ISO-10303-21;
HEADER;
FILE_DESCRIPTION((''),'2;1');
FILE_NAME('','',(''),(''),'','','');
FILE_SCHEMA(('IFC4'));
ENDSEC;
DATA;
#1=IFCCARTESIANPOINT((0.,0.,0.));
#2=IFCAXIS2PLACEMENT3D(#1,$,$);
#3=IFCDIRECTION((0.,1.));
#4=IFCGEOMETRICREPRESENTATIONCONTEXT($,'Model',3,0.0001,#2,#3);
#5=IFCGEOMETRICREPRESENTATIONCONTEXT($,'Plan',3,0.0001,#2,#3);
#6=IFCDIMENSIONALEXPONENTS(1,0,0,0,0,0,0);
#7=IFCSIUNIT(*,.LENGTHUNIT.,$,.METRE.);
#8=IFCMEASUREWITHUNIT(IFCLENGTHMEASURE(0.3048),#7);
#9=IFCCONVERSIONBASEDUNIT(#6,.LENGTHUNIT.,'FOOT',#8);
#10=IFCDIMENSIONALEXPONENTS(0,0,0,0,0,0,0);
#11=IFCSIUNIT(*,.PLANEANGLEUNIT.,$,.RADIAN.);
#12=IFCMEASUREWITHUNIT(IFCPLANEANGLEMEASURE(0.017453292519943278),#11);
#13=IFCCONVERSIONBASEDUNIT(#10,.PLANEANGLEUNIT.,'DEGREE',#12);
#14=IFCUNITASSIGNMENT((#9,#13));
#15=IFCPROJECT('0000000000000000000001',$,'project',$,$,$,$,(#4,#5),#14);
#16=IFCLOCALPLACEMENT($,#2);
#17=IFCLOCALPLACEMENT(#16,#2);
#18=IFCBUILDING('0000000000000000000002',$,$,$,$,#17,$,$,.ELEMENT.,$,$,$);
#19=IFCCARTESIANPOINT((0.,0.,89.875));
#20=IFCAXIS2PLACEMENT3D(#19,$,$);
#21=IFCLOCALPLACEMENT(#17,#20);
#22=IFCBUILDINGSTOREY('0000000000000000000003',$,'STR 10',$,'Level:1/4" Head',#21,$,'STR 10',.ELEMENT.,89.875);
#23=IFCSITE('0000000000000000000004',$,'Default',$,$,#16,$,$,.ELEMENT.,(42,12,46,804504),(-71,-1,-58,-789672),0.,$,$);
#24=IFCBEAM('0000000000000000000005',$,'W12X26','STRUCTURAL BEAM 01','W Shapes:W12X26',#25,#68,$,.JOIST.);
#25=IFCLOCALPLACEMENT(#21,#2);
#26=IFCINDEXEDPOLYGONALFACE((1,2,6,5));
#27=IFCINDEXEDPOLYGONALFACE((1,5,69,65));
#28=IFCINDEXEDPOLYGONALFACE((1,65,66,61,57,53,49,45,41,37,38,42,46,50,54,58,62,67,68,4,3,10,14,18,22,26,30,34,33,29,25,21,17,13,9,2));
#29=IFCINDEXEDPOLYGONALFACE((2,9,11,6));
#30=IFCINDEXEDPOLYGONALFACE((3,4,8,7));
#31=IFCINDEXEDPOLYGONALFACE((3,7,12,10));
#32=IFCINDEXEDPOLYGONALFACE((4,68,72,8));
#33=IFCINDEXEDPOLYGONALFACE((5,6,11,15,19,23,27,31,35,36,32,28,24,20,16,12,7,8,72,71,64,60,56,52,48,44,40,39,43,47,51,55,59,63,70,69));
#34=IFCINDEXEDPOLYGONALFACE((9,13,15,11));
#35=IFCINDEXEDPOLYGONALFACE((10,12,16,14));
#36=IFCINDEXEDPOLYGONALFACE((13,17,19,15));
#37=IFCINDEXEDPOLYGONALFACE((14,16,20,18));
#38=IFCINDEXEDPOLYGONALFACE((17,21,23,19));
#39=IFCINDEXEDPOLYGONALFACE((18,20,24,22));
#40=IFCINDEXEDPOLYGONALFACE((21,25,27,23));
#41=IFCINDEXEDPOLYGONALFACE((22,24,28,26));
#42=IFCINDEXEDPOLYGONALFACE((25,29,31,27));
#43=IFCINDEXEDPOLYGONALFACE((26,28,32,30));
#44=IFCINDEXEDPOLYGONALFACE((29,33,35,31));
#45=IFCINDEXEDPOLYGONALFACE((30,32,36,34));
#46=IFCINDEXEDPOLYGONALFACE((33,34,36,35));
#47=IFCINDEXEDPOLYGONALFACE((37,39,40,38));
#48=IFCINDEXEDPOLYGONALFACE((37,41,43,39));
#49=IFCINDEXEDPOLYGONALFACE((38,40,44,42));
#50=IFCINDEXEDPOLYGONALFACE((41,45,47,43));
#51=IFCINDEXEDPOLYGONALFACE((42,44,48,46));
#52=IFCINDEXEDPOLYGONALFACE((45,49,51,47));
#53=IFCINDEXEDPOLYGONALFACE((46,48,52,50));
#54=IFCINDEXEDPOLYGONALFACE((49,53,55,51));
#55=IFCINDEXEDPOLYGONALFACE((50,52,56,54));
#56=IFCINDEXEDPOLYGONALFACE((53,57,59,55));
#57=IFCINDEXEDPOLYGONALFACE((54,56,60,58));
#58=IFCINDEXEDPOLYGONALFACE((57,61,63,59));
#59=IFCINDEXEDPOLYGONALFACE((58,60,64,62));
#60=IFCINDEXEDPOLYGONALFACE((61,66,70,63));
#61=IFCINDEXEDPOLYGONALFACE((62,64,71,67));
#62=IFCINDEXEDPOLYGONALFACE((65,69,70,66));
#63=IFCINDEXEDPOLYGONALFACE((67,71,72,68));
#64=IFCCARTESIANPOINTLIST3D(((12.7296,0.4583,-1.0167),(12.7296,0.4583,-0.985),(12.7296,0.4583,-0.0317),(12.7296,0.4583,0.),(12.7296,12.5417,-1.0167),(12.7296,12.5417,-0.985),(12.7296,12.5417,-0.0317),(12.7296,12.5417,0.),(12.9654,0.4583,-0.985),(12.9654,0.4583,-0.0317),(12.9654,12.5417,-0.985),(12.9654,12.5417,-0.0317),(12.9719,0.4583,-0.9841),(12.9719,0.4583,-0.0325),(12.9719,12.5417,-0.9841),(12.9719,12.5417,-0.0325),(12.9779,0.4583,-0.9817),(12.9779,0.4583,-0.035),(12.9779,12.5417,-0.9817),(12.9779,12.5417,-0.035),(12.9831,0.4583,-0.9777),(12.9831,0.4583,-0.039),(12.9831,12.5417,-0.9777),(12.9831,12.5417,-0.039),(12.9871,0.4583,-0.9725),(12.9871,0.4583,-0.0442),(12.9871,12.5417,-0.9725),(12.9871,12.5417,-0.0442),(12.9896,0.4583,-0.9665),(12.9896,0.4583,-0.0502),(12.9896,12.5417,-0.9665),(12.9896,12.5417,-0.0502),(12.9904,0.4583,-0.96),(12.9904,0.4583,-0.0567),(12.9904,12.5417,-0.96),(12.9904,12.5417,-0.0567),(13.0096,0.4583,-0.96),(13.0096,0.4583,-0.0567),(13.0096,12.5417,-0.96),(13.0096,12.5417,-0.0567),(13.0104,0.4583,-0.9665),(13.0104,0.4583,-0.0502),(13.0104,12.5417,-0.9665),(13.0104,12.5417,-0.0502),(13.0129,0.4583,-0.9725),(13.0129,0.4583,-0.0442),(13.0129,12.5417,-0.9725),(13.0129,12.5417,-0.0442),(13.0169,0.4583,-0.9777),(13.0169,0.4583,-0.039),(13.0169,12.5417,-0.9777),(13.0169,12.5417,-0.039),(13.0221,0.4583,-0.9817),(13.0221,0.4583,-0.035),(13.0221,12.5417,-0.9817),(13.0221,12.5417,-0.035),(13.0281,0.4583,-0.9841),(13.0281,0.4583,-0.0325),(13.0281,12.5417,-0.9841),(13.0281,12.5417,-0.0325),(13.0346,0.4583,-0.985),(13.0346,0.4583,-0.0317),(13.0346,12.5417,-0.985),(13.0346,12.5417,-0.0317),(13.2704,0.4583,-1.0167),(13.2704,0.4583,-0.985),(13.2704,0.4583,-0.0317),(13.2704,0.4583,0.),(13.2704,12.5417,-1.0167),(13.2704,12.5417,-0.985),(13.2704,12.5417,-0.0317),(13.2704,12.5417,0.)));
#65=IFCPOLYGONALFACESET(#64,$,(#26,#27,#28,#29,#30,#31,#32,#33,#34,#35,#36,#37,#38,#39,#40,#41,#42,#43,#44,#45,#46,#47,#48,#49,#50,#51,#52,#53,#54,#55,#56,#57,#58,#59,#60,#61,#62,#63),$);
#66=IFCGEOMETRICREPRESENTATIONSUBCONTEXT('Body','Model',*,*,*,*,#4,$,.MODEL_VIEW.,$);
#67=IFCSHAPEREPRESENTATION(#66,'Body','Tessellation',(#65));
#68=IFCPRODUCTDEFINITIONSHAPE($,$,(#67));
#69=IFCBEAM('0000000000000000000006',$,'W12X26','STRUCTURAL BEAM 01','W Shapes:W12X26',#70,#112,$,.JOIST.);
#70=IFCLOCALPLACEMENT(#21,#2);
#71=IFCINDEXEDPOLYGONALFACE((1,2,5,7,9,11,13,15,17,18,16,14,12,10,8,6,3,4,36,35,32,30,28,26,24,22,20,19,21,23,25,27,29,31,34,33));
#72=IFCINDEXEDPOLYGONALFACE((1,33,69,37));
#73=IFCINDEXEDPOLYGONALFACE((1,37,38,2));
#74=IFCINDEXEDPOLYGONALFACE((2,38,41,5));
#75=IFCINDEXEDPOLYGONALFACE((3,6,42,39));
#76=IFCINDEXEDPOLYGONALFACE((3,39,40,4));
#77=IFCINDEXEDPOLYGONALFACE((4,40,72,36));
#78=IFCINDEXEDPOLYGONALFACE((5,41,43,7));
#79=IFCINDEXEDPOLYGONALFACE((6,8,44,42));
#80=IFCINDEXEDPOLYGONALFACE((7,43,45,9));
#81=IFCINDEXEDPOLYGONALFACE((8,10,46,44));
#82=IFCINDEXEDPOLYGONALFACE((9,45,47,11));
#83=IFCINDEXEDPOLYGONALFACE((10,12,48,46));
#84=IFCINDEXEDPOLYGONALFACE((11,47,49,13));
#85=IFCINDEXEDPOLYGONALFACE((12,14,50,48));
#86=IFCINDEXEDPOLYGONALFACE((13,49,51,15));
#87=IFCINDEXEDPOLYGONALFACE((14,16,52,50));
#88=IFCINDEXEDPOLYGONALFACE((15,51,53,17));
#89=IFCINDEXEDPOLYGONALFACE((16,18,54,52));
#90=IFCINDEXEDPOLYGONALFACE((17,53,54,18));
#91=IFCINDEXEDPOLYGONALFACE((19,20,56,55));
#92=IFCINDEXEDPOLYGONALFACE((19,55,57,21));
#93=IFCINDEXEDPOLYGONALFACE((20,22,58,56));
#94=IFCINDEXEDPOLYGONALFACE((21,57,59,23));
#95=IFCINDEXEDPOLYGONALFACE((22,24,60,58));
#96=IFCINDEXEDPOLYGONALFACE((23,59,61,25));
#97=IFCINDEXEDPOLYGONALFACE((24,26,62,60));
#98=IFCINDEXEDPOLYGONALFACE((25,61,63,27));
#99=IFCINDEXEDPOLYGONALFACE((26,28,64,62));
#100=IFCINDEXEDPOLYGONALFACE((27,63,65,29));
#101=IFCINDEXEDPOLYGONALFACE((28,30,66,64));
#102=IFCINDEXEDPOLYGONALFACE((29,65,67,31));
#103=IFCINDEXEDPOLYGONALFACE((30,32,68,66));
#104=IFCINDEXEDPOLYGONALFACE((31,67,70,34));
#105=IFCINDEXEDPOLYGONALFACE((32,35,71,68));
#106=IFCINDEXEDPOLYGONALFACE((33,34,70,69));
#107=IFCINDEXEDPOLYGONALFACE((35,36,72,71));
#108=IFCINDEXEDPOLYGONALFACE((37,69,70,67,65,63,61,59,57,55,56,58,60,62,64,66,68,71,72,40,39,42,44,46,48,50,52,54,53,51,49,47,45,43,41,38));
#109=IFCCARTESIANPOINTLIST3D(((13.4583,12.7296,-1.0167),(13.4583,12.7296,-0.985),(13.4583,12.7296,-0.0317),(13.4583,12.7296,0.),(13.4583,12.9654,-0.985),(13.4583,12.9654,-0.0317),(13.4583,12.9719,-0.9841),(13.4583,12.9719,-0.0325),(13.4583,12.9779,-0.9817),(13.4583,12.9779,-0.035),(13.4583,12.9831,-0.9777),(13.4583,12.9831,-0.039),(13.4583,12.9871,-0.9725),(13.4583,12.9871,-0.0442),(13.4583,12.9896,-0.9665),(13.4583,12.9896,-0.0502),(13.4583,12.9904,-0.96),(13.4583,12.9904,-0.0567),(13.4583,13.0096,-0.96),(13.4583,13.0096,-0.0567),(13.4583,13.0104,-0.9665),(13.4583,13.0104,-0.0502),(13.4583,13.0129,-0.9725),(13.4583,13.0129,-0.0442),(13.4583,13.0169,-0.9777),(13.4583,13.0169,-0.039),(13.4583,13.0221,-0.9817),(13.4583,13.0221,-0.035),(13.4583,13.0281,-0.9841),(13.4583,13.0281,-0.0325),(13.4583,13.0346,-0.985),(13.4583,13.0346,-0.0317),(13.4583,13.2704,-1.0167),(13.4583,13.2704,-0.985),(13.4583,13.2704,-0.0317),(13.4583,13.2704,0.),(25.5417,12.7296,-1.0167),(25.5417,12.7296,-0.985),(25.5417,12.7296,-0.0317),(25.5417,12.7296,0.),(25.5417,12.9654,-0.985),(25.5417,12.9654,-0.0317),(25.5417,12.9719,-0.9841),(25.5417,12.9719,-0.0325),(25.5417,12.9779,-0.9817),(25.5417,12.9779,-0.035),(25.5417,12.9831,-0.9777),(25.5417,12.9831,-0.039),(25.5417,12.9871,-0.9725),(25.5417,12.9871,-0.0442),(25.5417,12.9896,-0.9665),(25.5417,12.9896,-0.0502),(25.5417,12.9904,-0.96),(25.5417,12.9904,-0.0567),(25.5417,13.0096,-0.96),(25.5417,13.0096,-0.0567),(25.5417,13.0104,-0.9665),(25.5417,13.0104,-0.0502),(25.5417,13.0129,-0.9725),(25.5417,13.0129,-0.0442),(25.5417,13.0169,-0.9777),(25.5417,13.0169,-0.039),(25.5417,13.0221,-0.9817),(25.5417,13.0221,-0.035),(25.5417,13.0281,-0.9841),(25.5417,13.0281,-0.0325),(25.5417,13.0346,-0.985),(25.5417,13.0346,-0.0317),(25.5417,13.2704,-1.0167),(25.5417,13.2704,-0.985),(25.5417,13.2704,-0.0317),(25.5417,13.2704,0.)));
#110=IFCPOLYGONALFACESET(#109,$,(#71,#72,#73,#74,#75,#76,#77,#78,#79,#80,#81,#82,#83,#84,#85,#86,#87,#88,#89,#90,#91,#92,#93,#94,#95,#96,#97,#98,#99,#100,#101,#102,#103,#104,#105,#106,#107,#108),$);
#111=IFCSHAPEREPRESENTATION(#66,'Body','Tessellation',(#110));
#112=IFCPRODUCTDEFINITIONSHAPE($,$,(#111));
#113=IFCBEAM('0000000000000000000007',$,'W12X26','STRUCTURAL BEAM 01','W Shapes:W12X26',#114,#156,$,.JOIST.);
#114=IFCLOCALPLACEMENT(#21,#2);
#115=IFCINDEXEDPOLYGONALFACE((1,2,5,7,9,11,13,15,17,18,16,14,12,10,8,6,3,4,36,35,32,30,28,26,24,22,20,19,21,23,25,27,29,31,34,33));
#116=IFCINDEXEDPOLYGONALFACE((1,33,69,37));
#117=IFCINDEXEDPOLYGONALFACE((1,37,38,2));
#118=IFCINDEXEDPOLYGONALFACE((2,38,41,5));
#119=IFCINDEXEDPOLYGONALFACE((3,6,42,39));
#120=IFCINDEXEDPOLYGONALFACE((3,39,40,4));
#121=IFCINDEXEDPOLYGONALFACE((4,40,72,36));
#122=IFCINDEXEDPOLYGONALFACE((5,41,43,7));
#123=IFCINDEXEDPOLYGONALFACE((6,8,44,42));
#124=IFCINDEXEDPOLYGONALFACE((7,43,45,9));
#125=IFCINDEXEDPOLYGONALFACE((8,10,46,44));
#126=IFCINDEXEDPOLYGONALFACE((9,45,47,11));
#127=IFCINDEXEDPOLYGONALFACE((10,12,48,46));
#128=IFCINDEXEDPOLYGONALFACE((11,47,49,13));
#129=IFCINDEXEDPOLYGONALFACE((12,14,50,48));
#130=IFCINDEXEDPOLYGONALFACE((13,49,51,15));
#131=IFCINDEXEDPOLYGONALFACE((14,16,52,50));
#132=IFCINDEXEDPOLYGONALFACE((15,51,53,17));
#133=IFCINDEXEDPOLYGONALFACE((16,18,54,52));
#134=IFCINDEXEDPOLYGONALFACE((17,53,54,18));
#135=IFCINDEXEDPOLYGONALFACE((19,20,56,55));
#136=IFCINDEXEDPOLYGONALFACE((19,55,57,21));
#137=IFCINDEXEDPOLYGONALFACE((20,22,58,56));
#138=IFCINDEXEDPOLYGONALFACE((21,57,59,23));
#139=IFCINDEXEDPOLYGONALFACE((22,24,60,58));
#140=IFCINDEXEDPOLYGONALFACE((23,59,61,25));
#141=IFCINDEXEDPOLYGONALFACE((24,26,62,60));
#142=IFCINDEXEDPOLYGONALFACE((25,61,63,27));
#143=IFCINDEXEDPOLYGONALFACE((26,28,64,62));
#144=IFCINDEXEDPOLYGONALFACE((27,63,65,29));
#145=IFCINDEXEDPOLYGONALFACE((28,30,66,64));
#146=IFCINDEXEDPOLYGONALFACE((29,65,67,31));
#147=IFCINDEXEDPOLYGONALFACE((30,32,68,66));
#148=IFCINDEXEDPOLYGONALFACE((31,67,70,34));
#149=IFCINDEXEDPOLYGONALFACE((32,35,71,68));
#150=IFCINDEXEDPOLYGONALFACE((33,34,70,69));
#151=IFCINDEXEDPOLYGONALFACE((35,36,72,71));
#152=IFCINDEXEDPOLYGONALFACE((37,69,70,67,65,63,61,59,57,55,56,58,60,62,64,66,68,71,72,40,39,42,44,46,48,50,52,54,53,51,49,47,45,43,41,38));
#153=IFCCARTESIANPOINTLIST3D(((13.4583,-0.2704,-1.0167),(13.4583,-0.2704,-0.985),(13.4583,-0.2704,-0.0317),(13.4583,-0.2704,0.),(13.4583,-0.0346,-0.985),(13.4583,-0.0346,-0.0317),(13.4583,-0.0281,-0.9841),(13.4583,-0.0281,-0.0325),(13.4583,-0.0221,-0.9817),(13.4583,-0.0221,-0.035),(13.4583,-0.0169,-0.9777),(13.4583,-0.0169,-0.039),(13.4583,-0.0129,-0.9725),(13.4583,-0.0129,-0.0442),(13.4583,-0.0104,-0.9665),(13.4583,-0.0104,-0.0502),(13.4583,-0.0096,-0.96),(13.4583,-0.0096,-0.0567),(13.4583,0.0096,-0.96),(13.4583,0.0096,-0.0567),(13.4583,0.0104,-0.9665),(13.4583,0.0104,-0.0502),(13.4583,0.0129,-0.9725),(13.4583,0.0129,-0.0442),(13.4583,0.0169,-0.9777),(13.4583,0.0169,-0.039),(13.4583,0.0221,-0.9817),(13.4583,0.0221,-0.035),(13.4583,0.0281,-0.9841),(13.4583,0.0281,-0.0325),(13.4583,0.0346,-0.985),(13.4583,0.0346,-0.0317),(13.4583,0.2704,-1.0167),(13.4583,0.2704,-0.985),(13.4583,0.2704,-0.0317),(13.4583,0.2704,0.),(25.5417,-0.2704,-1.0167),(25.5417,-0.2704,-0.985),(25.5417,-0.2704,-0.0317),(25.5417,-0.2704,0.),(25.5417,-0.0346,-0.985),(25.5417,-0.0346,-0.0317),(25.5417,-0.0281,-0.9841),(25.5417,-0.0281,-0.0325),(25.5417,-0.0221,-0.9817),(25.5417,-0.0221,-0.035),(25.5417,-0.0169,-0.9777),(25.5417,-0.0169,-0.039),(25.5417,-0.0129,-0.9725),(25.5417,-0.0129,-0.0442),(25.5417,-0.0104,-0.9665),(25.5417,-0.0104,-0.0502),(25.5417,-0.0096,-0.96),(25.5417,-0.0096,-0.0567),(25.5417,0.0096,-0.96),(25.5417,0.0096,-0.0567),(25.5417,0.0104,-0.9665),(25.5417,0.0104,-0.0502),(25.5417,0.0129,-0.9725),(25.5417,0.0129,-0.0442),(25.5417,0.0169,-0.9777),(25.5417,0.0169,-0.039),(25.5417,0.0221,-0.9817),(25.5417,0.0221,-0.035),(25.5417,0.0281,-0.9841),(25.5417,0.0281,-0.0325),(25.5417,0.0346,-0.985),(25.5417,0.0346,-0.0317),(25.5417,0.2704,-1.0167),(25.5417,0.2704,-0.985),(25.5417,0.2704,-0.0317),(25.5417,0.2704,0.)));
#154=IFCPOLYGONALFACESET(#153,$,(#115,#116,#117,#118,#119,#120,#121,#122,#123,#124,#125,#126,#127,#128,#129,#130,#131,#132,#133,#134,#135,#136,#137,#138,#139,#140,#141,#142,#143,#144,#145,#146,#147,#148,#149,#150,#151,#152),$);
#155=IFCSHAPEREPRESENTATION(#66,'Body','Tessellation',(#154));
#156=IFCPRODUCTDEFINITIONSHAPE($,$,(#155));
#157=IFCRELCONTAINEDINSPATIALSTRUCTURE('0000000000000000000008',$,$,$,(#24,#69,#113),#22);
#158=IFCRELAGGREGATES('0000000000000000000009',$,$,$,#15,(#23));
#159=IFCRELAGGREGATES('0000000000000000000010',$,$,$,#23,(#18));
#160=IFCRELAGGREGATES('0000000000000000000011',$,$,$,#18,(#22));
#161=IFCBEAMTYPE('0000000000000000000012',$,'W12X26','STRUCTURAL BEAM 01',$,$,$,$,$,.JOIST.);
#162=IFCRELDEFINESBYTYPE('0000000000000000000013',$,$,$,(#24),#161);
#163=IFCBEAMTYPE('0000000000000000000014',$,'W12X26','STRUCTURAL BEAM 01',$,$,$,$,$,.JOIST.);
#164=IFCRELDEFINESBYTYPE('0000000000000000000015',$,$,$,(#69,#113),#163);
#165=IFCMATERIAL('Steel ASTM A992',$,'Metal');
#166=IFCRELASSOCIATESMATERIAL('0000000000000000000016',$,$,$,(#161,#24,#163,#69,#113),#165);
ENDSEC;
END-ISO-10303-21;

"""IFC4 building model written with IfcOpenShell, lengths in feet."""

from ifc_helpers import new_model, entity, si_unit, converted_unit, direction, frame, origin, place, context, subcontext, project, spatial, line, arc, indexed_curve, outline, extrude, source, transform, mapped, material, type_object, type_shapes, element, save


model = new_model("IFC4")

# Units and contexts
model_context = context("Model", 3, precision=0.0001, world=origin(), true_north=direction((0.0, 1.0)))
plan_context = context("Plan", 3, precision=0.0001, world=origin(), true_north=direction((0.0, 1.0)))
body_context = subcontext(model_context, "Body", "Model", "MODEL_VIEW")
ifc_project = project(units=[converted_unit("LENGTHUNIT", "FOOT", entity("IfcLengthMeasure", 0.3048), si_unit("LENGTHUNIT", "METRE"), dimensions=[1, 0, 0, 0, 0, 0, 0]), converted_unit("PLANEANGLEUNIT", "DEGREE", entity("IfcPlaneAngleMeasure", 0.017453292519943278), si_unit("PLANEANGLEUNIT", "RADIAN"), dimensions=[0, 0, 0, 0, 0, 0, 0])], contexts=[model_context, plan_context])

# Site, building, storey
site_placement = place(None, origin())
site = spatial("IfcSite", under=ifc_project, at=site_placement, Name="Default", CompositionType="ELEMENT", RefLatitude=(42, 12, 46, 804504), RefLongitude=(-71, -1, -58, -789672), RefElevation=0.0)
building_placement = place(site_placement, origin())
building = spatial("IfcBuilding", under=site, at=building_placement, CompositionType="ELEMENT")
storey_placement = place(building_placement, frame((0.0, 0.0, 89.875)))
storey = spatial("IfcBuildingStorey", under=building, at=storey_placement, Name="STR 10", ObjectType="Level:1/4\" Head", LongName="STR 10", CompositionType="ELEMENT", Elevation=89.875)

# Beams
ifc_material = material(Name="Steel ASTM A992", Category="Metal")
beam_type_1 = type_object("IfcBeamType", Name="W12X26", Description="STRUCTURAL BEAM 01", PredefinedType="JOIST", material=ifc_material)
shared_shape_1 = source(origin(), body_context, "Body", "SweptSolid", [
    extrude(outline(indexed_curve([(-0.2704, -0.4767), (-0.2704, -0.5083), (0.2704, -0.5083), (0.2704, -0.4767), (0.0346, -0.4767), (0.0169, -0.4693), (0.0096, -0.4517), (0.0096, 0.4517), (0.0169, 0.4693), (0.0346, 0.4767), (0.2704, 0.4767), (0.2704, 0.5083), (-0.2704, 0.5083), (-0.2704, 0.4767), (-0.0346, 0.4767), (-0.0169, 0.4693), (-0.0096, 0.4517), (-0.0096, -0.4517), (-0.0169, -0.4693), (-0.0346, -0.4767)], segments=[line(1, 2, 3, 4, 5), arc(5, 6, 7), line(7, 8), arc(8, 9, 10), line(10, 11, 12, 13, 14, 15), arc(15, 16, 17), line(17, 18), arc(18, 19, 20), line(20, 1)], self_intersect=False)), frame((-6.1033, 0.0, 0.0), z_axis=(-1.0, 0.0, 0.0), x_axis=(0.0, -1.0, 0.0)), (0.0, 0.0, -1.0), 12.0833),
])
type_shapes(beam_type_1, [shared_shape_1])
for number, where, z_axis, x_axis, name in (
    (1, (13.0, 6.5617, -0.5083), (0.0, 0.0, 1.0), (0.0, 1.0, 0.0), "W12X26"),
):
    element("IfcBeam", number, at=place(storey_placement, frame(where, z_axis=z_axis, x_axis=x_axis)), inside=storey, type_object=beam_type_1, material=ifc_material, Name=name, Description="STRUCTURAL BEAM 01", ObjectType="W Shapes:W12X26", PredefinedType="JOIST", context=body_context, shape_type="MappedRepresentation", body=[
        mapped(shared_shape_1, transform((0.0, 0.0, 0.0), scale=1.0)),
    ])
beam_type_2 = type_object("IfcBeamType", Name="W12X26", Description="STRUCTURAL BEAM 01", PredefinedType="JOIST", material=ifc_material)
shared_shape_2 = source(origin(), body_context, "Body", "SweptSolid", [
    extrude(outline(indexed_curve([(-0.2704, -0.4767), (-0.2704, -0.5083), (0.2704, -0.5083), (0.2704, -0.4767), (0.0346, -0.4767), (0.0169, -0.4693), (0.0096, -0.4517), (0.0096, 0.4517), (0.0169, 0.4693), (0.0346, 0.4767), (0.2704, 0.4767), (0.2704, 0.5083), (-0.2704, 0.5083), (-0.2704, 0.4767), (-0.0346, 0.4767), (-0.0169, 0.4693), (-0.0096, 0.4517), (-0.0096, -0.4517), (-0.0169, -0.4693), (-0.0346, -0.4767)], segments=[line(1, 2, 3, 4, 5), arc(5, 6, 7), line(7, 8), arc(8, 9, 10), line(10, 11, 12, 13, 14, 15), arc(15, 16, 17), line(17, 18), arc(18, 19, 20), line(20, 1)], self_intersect=False)), frame((-6.2267, 0.0, 0.0), z_axis=(-1.0, 0.0, 0.0), x_axis=(0.0, -1.0, 0.0)), (0.0, 0.0, -1.0), 12.0833),
])
type_shapes(beam_type_2, [shared_shape_2])
for number, where, name in (
    (2, (19.685, 13.0, -0.5083), "W12X26"),
    (3, (19.685, 0.0, -0.5083), "W12X26"),
):
    element("IfcBeam", number, at=place(storey_placement, frame(where)), inside=storey, type_object=beam_type_2, material=ifc_material, Name=name, Description="STRUCTURAL BEAM 01", ObjectType="W Shapes:W12X26", PredefinedType="JOIST", context=body_context, shape_type="MappedRepresentation", body=[
        mapped(shared_shape_2, transform((0.0, 0.0, 0.0), scale=1.0)),
    ])

save(model, "model.ifc")
